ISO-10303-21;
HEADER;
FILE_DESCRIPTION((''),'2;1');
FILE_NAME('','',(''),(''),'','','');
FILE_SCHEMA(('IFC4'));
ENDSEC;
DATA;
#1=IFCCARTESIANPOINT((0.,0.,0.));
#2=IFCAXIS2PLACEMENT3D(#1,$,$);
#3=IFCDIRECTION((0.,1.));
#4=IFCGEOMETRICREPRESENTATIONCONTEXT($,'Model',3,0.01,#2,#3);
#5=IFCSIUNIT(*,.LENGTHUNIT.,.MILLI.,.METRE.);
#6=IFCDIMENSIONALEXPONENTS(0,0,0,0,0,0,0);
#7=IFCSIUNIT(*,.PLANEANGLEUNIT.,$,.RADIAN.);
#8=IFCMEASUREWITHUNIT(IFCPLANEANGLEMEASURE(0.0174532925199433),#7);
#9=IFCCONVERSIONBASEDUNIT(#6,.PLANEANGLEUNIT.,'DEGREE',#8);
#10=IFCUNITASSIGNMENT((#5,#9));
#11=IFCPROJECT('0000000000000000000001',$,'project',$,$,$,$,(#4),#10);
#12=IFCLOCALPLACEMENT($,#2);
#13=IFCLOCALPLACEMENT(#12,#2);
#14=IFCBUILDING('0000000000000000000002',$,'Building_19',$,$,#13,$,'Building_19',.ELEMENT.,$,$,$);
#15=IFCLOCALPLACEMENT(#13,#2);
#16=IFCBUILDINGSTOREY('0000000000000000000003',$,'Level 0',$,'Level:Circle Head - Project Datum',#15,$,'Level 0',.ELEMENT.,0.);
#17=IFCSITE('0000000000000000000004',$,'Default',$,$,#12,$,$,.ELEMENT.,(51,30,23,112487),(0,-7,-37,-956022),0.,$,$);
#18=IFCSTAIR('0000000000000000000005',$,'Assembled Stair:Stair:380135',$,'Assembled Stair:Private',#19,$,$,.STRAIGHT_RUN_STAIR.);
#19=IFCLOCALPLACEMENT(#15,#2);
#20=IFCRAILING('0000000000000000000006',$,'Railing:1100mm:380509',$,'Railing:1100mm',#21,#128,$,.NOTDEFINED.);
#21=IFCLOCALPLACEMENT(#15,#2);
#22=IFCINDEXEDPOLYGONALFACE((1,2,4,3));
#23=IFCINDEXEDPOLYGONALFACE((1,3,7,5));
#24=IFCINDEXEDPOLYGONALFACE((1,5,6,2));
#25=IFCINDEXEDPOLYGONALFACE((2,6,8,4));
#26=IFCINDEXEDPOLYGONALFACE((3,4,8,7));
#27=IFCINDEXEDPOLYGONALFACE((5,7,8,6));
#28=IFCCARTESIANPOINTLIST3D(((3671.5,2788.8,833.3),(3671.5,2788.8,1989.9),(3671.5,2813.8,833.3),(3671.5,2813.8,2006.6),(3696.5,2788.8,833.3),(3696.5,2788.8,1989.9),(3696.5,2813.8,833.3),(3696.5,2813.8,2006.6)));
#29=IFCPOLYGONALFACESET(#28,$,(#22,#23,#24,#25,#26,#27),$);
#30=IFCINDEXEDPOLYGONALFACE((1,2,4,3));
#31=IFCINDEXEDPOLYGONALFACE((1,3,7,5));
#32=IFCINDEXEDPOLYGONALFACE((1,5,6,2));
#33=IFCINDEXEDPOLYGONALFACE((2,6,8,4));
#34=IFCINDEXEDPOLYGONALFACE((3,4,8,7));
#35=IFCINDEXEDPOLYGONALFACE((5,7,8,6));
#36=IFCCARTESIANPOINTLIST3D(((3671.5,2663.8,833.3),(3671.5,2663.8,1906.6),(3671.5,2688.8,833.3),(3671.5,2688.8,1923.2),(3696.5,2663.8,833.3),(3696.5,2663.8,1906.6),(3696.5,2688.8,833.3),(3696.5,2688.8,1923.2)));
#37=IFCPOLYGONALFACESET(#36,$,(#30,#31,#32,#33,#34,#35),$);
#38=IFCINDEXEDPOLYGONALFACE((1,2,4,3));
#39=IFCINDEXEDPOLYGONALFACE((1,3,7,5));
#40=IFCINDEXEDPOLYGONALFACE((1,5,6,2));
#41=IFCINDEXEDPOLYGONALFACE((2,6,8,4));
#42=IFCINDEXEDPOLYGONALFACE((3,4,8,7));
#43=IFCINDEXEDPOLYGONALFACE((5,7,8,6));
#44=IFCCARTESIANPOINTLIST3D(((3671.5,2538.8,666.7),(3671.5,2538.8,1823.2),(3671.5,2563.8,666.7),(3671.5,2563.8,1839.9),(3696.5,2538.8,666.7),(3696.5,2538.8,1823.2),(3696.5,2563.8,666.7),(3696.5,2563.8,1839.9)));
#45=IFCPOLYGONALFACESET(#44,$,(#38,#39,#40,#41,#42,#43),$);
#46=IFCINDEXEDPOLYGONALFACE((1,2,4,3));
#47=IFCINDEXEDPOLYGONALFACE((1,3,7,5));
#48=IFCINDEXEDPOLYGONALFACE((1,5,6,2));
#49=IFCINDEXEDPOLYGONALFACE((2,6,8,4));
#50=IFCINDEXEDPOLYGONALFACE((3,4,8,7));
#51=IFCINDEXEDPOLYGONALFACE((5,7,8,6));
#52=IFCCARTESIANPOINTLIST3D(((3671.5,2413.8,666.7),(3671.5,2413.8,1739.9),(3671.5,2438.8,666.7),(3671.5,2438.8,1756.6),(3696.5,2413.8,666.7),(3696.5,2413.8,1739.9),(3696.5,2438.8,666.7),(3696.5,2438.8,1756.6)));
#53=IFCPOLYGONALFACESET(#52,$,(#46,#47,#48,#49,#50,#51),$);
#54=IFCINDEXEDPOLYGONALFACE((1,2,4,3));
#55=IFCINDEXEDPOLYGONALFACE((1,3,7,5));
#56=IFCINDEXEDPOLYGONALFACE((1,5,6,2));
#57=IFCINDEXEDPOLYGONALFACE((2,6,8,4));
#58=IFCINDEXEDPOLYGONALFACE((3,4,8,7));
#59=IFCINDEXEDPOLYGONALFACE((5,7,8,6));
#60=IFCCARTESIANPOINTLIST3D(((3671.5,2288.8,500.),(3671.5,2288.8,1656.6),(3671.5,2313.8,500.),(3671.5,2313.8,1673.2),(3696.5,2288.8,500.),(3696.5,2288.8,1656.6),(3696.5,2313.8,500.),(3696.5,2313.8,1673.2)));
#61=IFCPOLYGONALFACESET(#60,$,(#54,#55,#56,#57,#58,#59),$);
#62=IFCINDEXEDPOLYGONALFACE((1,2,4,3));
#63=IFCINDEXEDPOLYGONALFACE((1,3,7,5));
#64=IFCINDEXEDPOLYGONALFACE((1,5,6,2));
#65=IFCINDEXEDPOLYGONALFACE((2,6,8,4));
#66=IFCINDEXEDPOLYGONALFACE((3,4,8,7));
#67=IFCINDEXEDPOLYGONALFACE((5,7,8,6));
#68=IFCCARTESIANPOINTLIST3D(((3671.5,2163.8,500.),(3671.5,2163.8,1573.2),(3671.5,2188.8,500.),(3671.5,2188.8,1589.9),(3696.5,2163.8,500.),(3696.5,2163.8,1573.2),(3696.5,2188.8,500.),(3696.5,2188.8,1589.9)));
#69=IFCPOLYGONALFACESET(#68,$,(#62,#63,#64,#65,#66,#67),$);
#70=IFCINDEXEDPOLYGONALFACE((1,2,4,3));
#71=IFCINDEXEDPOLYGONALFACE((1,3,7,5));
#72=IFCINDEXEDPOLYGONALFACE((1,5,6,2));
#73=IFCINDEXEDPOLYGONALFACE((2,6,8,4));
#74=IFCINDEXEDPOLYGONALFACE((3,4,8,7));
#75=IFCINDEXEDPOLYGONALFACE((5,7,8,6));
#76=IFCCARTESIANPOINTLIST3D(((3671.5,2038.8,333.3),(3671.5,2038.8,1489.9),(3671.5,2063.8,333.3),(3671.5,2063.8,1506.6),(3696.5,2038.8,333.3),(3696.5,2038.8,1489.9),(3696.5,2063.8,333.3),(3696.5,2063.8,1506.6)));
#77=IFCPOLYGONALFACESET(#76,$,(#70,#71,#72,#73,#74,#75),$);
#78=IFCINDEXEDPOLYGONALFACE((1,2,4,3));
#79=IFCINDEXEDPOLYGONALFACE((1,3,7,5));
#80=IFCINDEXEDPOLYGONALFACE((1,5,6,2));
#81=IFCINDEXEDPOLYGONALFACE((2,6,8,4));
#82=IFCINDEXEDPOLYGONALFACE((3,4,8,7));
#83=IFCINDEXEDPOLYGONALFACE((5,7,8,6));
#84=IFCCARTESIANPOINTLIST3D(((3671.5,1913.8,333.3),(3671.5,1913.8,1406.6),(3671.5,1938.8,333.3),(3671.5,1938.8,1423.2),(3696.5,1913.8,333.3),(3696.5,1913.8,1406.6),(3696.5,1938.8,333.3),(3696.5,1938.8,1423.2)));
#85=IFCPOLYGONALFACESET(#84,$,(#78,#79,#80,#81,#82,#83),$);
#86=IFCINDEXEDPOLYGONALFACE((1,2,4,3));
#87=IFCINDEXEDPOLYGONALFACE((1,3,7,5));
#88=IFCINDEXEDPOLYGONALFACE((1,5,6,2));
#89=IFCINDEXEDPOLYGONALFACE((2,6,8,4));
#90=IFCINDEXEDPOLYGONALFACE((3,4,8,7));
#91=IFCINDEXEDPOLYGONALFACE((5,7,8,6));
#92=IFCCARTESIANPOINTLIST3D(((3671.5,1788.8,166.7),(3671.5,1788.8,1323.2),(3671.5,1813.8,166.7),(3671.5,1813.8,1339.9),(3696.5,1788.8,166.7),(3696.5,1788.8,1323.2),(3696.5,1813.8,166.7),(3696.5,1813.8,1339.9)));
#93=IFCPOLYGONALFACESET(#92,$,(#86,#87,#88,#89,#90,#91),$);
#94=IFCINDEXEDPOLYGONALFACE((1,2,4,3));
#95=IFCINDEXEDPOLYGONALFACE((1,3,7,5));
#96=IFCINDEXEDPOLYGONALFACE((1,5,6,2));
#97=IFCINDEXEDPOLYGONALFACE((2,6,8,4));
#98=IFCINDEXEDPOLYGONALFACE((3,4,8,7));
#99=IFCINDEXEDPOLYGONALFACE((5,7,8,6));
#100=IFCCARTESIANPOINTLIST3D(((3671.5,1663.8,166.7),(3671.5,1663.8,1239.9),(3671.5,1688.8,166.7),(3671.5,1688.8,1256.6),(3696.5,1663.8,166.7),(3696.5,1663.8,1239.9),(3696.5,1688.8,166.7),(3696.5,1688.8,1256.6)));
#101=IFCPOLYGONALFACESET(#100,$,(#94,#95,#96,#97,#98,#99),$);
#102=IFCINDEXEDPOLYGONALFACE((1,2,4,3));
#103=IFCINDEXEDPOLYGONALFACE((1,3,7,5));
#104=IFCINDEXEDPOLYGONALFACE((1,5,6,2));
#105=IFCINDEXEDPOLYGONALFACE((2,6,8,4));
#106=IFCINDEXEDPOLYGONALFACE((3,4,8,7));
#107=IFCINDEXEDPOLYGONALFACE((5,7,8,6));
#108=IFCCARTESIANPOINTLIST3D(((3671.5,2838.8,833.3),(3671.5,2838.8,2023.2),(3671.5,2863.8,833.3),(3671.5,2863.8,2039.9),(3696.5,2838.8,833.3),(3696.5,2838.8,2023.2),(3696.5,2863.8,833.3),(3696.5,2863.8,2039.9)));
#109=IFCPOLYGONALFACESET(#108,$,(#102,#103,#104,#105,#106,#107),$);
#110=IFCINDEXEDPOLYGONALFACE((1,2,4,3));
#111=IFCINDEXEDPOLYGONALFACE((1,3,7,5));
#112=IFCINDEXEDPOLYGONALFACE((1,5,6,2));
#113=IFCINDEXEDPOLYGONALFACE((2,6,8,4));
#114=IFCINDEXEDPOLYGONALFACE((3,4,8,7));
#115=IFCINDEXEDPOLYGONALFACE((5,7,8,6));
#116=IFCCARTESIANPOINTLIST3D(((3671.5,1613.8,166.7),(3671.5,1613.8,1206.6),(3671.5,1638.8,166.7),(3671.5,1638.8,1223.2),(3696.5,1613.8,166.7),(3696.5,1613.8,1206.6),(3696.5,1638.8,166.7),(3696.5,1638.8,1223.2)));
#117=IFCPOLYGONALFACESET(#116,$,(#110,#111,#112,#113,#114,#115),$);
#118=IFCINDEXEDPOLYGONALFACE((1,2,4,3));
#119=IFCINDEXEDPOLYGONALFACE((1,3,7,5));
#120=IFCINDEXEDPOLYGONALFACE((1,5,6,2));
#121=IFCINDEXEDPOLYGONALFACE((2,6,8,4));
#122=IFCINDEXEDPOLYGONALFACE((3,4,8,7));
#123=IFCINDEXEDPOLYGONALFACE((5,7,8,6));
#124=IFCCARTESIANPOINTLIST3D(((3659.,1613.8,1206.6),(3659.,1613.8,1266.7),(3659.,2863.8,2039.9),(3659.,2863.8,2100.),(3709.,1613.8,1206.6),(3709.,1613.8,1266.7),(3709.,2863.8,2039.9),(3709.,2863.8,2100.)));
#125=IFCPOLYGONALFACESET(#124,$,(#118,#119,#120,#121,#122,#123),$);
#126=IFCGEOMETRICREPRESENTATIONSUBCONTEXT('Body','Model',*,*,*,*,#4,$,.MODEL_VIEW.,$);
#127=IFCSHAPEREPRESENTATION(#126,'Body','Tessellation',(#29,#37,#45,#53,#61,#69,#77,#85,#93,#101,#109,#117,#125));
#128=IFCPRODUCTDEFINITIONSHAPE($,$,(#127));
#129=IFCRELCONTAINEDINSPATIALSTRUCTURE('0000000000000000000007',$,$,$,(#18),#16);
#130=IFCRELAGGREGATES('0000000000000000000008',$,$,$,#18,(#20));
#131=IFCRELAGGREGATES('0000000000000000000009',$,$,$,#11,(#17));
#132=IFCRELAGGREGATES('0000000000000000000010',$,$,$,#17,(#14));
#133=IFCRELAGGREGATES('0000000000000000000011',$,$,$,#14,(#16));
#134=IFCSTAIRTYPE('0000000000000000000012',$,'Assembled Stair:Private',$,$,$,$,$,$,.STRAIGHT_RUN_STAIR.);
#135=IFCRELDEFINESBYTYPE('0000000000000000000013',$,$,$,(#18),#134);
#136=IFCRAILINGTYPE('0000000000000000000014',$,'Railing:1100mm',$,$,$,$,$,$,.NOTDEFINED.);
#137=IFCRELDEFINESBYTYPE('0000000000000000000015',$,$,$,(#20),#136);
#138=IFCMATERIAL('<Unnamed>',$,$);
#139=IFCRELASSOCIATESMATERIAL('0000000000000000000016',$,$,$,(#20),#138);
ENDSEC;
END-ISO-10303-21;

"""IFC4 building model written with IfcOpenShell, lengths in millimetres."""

from ifc_helpers import new_model, entity, si_unit, converted_unit, direction, frame, origin, place, context, subcontext, project, spatial, indexed_curve, outline, extrude, material, type_object, element, aggregate, save


model = new_model("IFC4")

# Units and contexts
model_context = context("Model", 3, precision=0.01, world=origin(), true_north=direction((0.0, 1.0)))
body_context = subcontext(model_context, "Body", "Model", "MODEL_VIEW")
ifc_project = project(units=[si_unit("LENGTHUNIT", "METRE", prefix="MILLI"), converted_unit("PLANEANGLEUNIT", "DEGREE", entity("IfcPlaneAngleMeasure", 0.0174532925199433), si_unit("PLANEANGLEUNIT", "RADIAN"), dimensions=[0, 0, 0, 0, 0, 0, 0])], contexts=[model_context])

# Site, building, storey
site_placement = place(None, origin())
site = spatial("IfcSite", under=ifc_project, at=site_placement, Name="Default", CompositionType="ELEMENT", RefLatitude=(51, 30, 23, 112487), RefLongitude=(0, -7, -37, -956022), RefElevation=0.0)
building_placement = place(site_placement, origin())
building = spatial("IfcBuilding", under=site, at=building_placement, Name="Building_19", LongName="Building_19", CompositionType="ELEMENT")
storey_placement = place(building_placement, origin())
storey = spatial("IfcBuildingStorey", under=building, at=storey_placement, Name="Level 0", ObjectType="Level:Circle Head - Project Datum", LongName="Level 0", CompositionType="ELEMENT", Elevation=0.0)

# Stair, railing
stair_type = type_object("IfcStairType", Name="Assembled Stair:Private", PredefinedType="STRAIGHT_RUN_STAIR")
ifc_material_1 = material(Name="<Unnamed>")
railing_type = type_object("IfcRailingType", Name="Railing:1100mm", PredefinedType="NOTDEFINED")
stair_1_placement = place(storey_placement, origin())
stair_1 = element("IfcStair", 1, at=stair_1_placement, inside=storey, type_object=stair_type, Name="Assembled Stair:Stair:380135", ObjectType="Assembled Stair:Private", PredefinedType="STRAIGHT_RUN_STAIR")
railing_1_placement = place(stair_1_placement, origin())
railing_1 = element("IfcRailing", 2, at=railing_1_placement, type_object=railing_type, material=ifc_material_1, Name="Railing:1100mm:380509", ObjectType="Railing:1100mm", PredefinedType="NOTDEFINED", context=body_context, shape_type="SweptSolid", body=[
    extrude(outline(indexed_curve([(-12.5, -582.5), (12.5, -582.5), (12.5, 590.8), (-12.5, 574.1), (-12.5, -582.5)], self_intersect=False)), frame((3671.5, 2801.3, 1415.8), z_axis=(1.0, 0.0, 0.0), x_axis=(0.0, 1.0, 0.0)), (0.0, 0.0, 1.0), 25.0),
    extrude(outline(indexed_curve([(-12.5, -540.8), (12.5, -540.8), (12.5, 549.1), (-12.5, 532.5), (-12.5, -540.8)], self_intersect=False)), frame((3671.5, 2676.3, 1374.1), z_axis=(1.0, 0.0, 0.0), x_axis=(0.0, 1.0, 0.0)), (0.0, 0.0, 1.0), 25.0),
    extrude(outline(indexed_curve([(-12.5, -582.5), (12.5, -582.5), (12.5, 590.8), (-12.5, 574.1), (-12.5, -582.5)], self_intersect=False)), frame((3671.5, 2551.3, 1249.1), z_axis=(1.0, 0.0, 0.0), x_axis=(0.0, 1.0, 0.0)), (0.0, 0.0, 1.0), 25.0),
    extrude(outline(indexed_curve([(-12.5, -540.8), (12.5, -540.8), (12.5, 549.1), (-12.5, 532.5), (-12.5, -540.8)], self_intersect=False)), frame((3671.5, 2426.3, 1207.5), z_axis=(1.0, 0.0, 0.0), x_axis=(0.0, 1.0, 0.0)), (0.0, 0.0, 1.0), 25.0),
    extrude(outline(indexed_curve([(-12.5, -582.5), (12.5, -582.5), (12.5, 590.8), (-12.5, 574.1), (-12.5, -582.5)], self_intersect=False)), frame((3671.5, 2301.3, 1082.5), z_axis=(1.0, 0.0, 0.0), x_axis=(0.0, 1.0, 0.0)), (0.0, 0.0, 1.0), 25.0),
    extrude(outline(indexed_curve([(-12.5, -540.8), (12.5, -540.8), (12.5, 549.1), (-12.5, 532.5), (-12.5, -540.8)], self_intersect=False)), frame((3671.5, 2176.3, 1040.8), z_axis=(1.0, 0.0, 0.0), x_axis=(0.0, 1.0, 0.0)), (0.0, 0.0, 1.0), 25.0),
    extrude(outline(indexed_curve([(-12.5, -582.5), (12.5, -582.5), (12.5, 590.8), (-12.5, 574.1), (-12.5, -582.5)], self_intersect=False)), frame((3671.5, 2051.3, 915.8), z_axis=(1.0, 0.0, 0.0), x_axis=(0.0, 1.0, 0.0)), (0.0, 0.0, 1.0), 25.0),
    extrude(outline(indexed_curve([(-12.5, -540.8), (12.5, -540.8), (12.5, 549.1), (-12.5, 532.5), (-12.5, -540.8)], self_intersect=False)), frame((3671.5, 1926.3, 874.1), z_axis=(1.0, 0.0, 0.0), x_axis=(0.0, 1.0, 0.0)), (0.0, 0.0, 1.0), 25.0),
    extrude(outline(indexed_curve([(-12.5, -582.5), (12.5, -582.5), (12.5, 590.8), (-12.5, 574.1), (-12.5, -582.5)], self_intersect=False)), frame((3671.5, 1801.3, 749.1), z_axis=(1.0, 0.0, 0.0), x_axis=(0.0, 1.0, 0.0)), (0.0, 0.0, 1.0), 25.0),
    extrude(outline(indexed_curve([(-12.5, -540.8), (12.5, -540.8), (12.5, 549.1), (-12.5, 532.5), (-12.5, -540.8)], self_intersect=False)), frame((3671.5, 1676.3, 707.5), z_axis=(1.0, 0.0, 0.0), x_axis=(0.0, 1.0, 0.0)), (0.0, 0.0, 1.0), 25.0),
    extrude(outline(indexed_curve([(-12.5, -599.1), (12.5, -599.1), (12.5, 607.5), (-12.5, 590.8), (-12.5, -599.1)], self_intersect=False)), frame((3671.5, 2851.3, 1432.5), z_axis=(1.0, 0.0, 0.0), x_axis=(0.0, 1.0, 0.0)), (0.0, 0.0, 1.0), 25.0),
    extrude(outline(indexed_curve([(-12.5, -524.1), (12.5, -524.1), (12.5, 532.5), (-12.5, 515.8), (-12.5, -524.1)], self_intersect=False)), frame((3671.5, 1626.3, 690.8), z_axis=(1.0, 0.0, 0.0), x_axis=(0.0, 1.0, 0.0)), (0.0, 0.0, 1.0), 25.0),
    extrude(outline(indexed_curve([(-767.8, -25.0), (734.5, -25.0), (767.8, 25.0), (-734.5, 25.0), (-767.8, -25.0)], self_intersect=False)), frame((3659.0, 2238.8, 1653.3), z_axis=(1.0, 0.0, 0.0), x_axis=(0.0, 0.83205, 0.5547)), (0.0, 0.0, 1.0), 50.0),
])
aggregate(stair_1, [railing_1])

save(model, "model.ifc")
